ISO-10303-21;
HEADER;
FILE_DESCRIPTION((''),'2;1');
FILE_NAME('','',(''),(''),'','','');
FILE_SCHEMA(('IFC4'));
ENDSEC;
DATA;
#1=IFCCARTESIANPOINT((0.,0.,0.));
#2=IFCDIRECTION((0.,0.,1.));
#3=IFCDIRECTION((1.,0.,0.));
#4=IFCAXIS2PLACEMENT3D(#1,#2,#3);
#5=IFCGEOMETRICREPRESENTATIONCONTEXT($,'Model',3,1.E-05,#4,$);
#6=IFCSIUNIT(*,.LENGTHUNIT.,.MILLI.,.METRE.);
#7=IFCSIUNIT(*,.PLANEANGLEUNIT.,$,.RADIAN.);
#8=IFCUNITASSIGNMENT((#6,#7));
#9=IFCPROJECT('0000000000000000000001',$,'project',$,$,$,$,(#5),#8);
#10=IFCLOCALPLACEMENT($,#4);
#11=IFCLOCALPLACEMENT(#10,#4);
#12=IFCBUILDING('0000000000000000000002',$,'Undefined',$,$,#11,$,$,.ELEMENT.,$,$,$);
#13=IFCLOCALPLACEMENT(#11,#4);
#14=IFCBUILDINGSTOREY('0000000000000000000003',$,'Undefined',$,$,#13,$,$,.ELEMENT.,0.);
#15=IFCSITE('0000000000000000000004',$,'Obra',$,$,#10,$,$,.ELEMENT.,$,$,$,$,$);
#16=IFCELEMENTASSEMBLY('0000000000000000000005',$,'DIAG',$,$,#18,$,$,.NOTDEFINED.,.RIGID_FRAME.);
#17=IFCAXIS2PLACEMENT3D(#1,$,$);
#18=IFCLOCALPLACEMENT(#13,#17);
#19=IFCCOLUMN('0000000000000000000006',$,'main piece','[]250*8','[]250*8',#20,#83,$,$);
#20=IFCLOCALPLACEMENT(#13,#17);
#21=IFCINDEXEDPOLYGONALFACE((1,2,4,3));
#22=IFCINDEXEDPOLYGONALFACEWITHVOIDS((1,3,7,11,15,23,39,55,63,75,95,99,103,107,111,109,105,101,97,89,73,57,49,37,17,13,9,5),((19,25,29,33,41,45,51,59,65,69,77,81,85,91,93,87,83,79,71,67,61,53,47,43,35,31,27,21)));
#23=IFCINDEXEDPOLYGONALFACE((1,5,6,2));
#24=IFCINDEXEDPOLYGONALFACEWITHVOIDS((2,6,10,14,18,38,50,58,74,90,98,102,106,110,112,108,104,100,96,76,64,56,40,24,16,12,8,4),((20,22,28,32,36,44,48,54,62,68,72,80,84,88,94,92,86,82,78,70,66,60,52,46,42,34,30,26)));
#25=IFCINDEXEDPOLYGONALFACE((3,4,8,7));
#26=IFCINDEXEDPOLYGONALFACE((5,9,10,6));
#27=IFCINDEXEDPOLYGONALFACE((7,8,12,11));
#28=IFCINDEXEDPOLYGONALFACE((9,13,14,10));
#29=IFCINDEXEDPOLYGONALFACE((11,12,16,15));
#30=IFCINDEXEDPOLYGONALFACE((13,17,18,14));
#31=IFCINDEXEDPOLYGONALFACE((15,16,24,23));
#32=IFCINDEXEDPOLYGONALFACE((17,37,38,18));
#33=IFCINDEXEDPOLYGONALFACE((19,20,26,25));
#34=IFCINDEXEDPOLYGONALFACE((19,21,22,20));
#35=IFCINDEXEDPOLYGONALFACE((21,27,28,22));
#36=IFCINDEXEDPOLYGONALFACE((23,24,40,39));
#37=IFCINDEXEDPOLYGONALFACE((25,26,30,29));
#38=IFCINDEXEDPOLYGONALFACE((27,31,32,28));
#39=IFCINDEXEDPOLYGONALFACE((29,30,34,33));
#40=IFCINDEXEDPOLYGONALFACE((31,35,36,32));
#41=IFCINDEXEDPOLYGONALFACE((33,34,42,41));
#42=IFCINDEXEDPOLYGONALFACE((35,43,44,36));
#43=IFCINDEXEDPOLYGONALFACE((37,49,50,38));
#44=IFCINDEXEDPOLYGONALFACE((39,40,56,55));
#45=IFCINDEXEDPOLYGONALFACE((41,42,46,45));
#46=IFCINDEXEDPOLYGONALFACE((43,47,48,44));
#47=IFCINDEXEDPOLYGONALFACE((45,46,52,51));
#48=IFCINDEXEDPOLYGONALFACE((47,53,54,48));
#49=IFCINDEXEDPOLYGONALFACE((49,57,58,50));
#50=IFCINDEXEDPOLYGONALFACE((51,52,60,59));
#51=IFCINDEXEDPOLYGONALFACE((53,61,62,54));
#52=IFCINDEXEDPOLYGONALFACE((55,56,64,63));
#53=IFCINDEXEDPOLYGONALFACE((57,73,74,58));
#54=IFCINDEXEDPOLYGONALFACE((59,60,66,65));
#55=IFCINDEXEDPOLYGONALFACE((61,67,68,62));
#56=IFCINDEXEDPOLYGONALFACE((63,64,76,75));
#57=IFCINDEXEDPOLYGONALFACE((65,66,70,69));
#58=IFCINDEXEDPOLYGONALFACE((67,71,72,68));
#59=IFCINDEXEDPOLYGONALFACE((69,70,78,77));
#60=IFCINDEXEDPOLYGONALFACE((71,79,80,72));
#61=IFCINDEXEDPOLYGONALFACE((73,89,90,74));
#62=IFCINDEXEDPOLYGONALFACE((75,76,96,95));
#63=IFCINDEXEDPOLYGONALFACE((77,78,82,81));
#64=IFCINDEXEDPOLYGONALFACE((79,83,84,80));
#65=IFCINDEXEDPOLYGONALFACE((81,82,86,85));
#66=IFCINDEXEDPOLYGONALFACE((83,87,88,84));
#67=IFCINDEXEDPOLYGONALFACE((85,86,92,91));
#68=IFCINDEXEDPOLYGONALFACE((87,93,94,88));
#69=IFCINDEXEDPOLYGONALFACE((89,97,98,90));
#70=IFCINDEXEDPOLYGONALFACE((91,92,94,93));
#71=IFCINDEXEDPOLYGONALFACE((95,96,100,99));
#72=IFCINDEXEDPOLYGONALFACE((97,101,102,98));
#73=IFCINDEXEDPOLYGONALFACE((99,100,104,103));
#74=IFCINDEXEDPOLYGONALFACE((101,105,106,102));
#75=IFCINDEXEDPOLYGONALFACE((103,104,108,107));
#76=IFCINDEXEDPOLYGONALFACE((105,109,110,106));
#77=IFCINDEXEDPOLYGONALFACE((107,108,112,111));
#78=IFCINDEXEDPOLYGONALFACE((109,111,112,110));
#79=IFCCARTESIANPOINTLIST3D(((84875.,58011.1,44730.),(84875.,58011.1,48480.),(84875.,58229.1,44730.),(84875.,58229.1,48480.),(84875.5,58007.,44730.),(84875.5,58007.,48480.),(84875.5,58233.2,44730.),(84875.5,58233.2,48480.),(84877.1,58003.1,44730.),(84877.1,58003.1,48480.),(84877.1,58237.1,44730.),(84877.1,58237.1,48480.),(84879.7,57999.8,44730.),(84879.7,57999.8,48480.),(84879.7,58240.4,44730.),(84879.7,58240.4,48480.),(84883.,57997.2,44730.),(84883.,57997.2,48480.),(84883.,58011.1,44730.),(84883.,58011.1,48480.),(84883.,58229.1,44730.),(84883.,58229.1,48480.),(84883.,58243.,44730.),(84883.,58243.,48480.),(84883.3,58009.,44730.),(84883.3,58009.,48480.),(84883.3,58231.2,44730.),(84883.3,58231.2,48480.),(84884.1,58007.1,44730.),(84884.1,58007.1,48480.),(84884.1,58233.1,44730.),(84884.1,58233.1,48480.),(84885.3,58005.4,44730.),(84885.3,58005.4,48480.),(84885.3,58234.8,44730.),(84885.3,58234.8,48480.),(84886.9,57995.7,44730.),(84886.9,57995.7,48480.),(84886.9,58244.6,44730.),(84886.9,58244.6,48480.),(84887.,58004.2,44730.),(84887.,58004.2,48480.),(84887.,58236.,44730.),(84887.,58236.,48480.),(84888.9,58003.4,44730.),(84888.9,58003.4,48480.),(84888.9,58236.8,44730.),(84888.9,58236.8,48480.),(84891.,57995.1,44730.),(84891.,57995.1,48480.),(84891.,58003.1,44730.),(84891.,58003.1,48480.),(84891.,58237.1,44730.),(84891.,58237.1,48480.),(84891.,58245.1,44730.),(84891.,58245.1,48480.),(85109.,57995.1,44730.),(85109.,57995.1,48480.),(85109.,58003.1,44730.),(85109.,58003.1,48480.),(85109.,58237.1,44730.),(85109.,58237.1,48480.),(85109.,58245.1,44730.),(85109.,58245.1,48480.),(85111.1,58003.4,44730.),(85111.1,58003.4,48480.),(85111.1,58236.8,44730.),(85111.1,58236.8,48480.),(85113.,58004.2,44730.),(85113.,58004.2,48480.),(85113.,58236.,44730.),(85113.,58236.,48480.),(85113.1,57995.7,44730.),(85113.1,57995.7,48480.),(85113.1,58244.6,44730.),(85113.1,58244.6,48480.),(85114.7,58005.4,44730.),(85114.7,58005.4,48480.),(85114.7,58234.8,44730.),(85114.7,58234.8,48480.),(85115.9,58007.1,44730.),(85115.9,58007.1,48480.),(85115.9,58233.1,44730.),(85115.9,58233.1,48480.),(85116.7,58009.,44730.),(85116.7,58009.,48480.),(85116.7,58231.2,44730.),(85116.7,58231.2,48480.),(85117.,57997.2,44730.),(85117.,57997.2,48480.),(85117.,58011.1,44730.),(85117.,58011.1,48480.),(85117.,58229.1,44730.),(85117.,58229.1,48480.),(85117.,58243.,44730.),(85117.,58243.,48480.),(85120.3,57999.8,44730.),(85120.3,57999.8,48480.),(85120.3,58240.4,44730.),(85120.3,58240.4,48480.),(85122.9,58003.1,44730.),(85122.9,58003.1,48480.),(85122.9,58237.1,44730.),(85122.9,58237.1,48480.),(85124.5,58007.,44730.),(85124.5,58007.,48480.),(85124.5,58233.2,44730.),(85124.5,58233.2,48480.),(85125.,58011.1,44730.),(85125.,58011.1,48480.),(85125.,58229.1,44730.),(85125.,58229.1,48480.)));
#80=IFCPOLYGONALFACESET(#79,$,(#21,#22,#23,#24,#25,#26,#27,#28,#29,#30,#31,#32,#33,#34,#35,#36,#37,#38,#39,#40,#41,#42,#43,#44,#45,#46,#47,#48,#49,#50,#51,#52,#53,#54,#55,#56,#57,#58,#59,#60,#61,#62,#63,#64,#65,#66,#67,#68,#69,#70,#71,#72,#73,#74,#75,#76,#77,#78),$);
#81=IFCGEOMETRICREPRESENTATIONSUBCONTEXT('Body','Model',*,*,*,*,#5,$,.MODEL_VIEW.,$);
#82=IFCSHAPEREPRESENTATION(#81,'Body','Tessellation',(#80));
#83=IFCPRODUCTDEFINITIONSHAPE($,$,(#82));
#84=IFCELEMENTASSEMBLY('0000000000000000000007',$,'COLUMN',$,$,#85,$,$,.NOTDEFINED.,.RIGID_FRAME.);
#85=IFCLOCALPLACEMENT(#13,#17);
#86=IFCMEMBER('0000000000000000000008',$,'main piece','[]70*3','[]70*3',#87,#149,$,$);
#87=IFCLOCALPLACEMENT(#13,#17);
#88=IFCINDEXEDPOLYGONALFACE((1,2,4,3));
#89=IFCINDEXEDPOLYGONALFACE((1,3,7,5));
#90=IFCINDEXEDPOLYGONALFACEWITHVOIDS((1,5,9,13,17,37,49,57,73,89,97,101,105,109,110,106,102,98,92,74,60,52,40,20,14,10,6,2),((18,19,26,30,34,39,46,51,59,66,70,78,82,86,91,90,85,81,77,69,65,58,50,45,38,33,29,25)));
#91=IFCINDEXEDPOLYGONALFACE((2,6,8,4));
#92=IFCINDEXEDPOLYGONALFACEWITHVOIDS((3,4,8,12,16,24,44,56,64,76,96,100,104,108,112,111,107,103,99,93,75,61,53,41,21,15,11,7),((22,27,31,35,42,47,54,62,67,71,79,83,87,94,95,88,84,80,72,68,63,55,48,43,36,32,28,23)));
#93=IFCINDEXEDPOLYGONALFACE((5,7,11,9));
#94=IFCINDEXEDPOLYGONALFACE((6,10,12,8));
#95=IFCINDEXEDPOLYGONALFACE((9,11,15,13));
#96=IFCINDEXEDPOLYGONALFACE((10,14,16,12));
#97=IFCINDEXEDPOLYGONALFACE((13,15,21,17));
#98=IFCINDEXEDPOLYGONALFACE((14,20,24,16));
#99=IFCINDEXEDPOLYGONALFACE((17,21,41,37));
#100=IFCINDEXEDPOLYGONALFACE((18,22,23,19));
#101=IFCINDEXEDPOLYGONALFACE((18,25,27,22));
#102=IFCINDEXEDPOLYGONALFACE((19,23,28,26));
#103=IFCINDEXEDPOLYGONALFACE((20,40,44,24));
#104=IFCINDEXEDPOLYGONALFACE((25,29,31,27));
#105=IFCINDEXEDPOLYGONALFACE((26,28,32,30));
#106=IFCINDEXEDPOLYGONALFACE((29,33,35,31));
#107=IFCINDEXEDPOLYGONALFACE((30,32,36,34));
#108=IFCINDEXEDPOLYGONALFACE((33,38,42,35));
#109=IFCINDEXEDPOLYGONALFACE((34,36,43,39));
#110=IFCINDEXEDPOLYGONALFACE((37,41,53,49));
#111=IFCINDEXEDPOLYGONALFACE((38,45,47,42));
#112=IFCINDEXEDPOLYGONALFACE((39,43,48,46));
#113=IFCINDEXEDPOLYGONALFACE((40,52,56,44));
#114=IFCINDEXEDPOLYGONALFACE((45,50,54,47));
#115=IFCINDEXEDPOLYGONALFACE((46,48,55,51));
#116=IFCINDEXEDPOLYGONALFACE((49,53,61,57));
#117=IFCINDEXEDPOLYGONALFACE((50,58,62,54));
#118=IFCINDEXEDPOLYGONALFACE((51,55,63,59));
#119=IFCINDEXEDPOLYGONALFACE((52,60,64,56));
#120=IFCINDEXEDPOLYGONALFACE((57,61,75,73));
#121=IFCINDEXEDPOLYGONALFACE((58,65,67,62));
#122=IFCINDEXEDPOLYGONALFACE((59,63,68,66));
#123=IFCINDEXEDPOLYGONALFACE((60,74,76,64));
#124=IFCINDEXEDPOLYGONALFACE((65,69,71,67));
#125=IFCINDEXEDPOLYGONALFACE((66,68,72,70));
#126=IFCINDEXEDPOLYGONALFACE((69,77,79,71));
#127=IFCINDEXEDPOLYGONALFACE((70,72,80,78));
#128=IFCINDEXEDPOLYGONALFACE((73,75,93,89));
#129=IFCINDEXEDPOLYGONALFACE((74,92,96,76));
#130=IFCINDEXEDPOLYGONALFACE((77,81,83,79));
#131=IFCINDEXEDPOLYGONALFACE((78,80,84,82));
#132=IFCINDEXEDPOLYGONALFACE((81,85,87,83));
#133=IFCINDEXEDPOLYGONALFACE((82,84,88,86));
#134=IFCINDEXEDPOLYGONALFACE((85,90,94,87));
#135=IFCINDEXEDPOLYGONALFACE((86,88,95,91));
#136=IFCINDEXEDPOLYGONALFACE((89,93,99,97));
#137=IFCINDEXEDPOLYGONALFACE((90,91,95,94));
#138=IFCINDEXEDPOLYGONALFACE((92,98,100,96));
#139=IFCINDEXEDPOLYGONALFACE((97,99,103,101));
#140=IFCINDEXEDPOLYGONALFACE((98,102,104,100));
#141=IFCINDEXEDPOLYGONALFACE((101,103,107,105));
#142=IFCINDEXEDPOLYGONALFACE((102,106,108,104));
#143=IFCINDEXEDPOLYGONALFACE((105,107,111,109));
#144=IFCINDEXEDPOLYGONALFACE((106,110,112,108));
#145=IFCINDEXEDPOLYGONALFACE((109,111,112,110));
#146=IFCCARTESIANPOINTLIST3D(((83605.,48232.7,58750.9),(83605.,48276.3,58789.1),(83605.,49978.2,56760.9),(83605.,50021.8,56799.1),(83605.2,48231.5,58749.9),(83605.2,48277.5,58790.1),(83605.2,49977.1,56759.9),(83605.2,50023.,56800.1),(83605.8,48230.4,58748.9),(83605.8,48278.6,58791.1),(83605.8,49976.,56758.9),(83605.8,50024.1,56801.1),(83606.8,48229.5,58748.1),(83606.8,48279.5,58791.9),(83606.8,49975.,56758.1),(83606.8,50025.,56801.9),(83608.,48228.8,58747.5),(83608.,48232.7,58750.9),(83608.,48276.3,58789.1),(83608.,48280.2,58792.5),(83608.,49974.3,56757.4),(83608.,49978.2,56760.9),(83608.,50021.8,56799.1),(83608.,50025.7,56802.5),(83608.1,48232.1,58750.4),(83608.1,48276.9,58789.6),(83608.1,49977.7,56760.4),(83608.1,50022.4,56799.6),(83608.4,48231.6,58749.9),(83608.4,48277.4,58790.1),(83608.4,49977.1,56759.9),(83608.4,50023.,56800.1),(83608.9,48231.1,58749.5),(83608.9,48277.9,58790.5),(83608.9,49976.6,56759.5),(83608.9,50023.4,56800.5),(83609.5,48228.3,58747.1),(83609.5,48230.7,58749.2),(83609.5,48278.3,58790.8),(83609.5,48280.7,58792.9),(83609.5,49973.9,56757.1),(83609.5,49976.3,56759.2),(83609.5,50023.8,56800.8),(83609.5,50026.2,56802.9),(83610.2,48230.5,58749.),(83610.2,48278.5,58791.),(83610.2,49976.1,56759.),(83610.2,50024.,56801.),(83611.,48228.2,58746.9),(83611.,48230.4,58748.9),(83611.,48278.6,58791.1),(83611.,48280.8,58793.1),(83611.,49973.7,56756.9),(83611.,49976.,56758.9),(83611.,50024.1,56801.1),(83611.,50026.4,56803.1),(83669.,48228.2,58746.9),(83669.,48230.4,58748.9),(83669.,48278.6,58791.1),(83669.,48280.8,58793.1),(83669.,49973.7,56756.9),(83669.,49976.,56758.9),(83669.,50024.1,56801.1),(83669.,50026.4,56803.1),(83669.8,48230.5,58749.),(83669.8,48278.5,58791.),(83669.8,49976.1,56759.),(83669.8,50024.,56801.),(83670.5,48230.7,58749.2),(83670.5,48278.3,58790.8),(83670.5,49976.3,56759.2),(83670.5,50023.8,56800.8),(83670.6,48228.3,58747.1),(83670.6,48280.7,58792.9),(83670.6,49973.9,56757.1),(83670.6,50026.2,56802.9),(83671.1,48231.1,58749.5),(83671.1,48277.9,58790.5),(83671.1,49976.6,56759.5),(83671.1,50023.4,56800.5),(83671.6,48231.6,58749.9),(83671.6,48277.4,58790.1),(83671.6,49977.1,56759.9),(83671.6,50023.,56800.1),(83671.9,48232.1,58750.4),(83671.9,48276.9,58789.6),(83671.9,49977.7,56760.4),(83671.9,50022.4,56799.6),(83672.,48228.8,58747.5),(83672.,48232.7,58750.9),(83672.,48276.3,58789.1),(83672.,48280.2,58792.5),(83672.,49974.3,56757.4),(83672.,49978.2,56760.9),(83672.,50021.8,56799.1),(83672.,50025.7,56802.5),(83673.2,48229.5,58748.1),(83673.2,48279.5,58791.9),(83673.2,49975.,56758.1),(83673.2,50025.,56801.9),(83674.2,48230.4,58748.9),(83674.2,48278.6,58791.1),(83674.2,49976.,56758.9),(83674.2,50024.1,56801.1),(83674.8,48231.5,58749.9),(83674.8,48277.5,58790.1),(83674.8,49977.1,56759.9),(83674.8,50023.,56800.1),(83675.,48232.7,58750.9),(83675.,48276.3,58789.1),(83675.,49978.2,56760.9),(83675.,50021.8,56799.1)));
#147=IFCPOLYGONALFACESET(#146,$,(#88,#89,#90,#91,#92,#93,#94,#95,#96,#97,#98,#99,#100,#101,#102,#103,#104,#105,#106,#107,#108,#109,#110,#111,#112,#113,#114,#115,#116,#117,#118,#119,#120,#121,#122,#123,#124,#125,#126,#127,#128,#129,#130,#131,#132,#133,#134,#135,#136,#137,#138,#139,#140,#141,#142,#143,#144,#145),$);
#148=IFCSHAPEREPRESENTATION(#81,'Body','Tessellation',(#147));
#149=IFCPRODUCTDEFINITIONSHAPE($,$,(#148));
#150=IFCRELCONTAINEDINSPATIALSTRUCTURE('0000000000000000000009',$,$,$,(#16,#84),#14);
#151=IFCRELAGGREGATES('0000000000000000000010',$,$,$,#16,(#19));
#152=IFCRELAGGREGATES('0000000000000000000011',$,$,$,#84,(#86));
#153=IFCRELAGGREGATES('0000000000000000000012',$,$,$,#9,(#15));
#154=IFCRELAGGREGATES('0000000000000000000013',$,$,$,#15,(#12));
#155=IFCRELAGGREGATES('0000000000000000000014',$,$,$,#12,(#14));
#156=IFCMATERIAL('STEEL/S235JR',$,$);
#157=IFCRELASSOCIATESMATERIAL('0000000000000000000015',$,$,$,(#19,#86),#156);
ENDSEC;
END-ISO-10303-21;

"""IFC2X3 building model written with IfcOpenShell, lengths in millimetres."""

from ifc_helpers import new_model, si_unit, frame, origin_with_axes, origin_2d_with_axis, place, context, subcontext, project, spatial, hollow_rectangle, extrude, material, element, aggregate, save


model = new_model("IFC2X3")

# Units and contexts
model_context = context("Model", 3, precision=1e-05, world=origin_with_axes())
body_context = subcontext(model_context, "Body", "Model", "MODEL_VIEW")
ifc_project = project(units=[si_unit("LENGTHUNIT", "METRE", prefix="MILLI"), si_unit("PLANEANGLEUNIT", "RADIAN")], contexts=[model_context])

# Site, building, storey
site_placement = place(None, origin_with_axes())
site = spatial("IfcSite", under=ifc_project, at=site_placement, Name="Obra", CompositionType="ELEMENT")
building_placement = place(site_placement, origin_with_axes())
building = spatial("IfcBuilding", under=site, at=building_placement, Name="Undefined", CompositionType="ELEMENT")
storey_placement = place(building_placement, origin_with_axes())
storey = spatial("IfcBuildingStorey", under=building, at=storey_placement, Name="Undefined", CompositionType="ELEMENT", Elevation=0.0)

# Element assembly, column
ifc_material = material(Name="STEEL/S235JR")
assembly_1_placement = place(storey_placement, origin_with_axes())
assembly_1 = element("IfcElementAssembly", 1, at=assembly_1_placement, inside=storey, Name="DIAG", AssemblyPlace="NOTDEFINED", PredefinedType="RIGID_FRAME")
column_1_placement = place(assembly_1_placement, frame((85000.0, 58120.1, 44730.0), z_axis=(0.0, 0.0, 1.0), x_axis=(-1.0, 0.0, 0.0)))
column_1 = element("IfcColumn", 2, at=column_1_placement, material=ifc_material, Name="main piece", Description="[]250*8", ObjectType="[]250*8", context=body_context, shape_type="SweptSolid", body=[
    extrude(hollow_rectangle(XDim=250.0, YDim=250.0, WallThickness=8.0, InnerFilletRadius=8.0, OuterFilletRadius=16.0, at=origin_2d_with_axis()), frame((0.0, 0.0, 3750.0), z_axis=(0.0, 0.0, -1.0), x_axis=(0.0, 1.0, 0.0)), (0.0, 0.0, 1.0), 3750.0),
])
aggregate(assembly_1, [column_1])

# Element assembly, member
assembly_2_placement = place(storey_placement, origin_with_axes())
assembly_2 = element("IfcElementAssembly", 3, at=assembly_2_placement, inside=storey, Name="COLUMN", AssemblyPlace="NOTDEFINED", PredefinedType="RIGID_FRAME")
member_1_placement = place(assembly_2_placement, frame((83640.0, 50000.0, 56780.0), z_axis=(1.0, 0.0, 0.0), x_axis=(0.0, -0.659423, 0.751772)))
member_1 = element("IfcMember", 4, at=member_1_placement, material=ifc_material, Name="main piece", Description="[]70*3", ObjectType="[]70*3", context=body_context, shape_type="SweptSolid", body=[
    extrude(hollow_rectangle(XDim=70.0, YDim=70.0, WallThickness=3.0, InnerFilletRadius=3.0, OuterFilletRadius=6.0, at=origin_2d_with_axis()), frame((2647.1, 0.0, 0.0), z_axis=(-1.0, 0.0, 0.0), x_axis=(0.0, -1.0, 0.0)), (0.0, 0.0, 1.0), 2647.1),
])
aggregate(assembly_2, [member_1])

save(model, "model.ifc")
